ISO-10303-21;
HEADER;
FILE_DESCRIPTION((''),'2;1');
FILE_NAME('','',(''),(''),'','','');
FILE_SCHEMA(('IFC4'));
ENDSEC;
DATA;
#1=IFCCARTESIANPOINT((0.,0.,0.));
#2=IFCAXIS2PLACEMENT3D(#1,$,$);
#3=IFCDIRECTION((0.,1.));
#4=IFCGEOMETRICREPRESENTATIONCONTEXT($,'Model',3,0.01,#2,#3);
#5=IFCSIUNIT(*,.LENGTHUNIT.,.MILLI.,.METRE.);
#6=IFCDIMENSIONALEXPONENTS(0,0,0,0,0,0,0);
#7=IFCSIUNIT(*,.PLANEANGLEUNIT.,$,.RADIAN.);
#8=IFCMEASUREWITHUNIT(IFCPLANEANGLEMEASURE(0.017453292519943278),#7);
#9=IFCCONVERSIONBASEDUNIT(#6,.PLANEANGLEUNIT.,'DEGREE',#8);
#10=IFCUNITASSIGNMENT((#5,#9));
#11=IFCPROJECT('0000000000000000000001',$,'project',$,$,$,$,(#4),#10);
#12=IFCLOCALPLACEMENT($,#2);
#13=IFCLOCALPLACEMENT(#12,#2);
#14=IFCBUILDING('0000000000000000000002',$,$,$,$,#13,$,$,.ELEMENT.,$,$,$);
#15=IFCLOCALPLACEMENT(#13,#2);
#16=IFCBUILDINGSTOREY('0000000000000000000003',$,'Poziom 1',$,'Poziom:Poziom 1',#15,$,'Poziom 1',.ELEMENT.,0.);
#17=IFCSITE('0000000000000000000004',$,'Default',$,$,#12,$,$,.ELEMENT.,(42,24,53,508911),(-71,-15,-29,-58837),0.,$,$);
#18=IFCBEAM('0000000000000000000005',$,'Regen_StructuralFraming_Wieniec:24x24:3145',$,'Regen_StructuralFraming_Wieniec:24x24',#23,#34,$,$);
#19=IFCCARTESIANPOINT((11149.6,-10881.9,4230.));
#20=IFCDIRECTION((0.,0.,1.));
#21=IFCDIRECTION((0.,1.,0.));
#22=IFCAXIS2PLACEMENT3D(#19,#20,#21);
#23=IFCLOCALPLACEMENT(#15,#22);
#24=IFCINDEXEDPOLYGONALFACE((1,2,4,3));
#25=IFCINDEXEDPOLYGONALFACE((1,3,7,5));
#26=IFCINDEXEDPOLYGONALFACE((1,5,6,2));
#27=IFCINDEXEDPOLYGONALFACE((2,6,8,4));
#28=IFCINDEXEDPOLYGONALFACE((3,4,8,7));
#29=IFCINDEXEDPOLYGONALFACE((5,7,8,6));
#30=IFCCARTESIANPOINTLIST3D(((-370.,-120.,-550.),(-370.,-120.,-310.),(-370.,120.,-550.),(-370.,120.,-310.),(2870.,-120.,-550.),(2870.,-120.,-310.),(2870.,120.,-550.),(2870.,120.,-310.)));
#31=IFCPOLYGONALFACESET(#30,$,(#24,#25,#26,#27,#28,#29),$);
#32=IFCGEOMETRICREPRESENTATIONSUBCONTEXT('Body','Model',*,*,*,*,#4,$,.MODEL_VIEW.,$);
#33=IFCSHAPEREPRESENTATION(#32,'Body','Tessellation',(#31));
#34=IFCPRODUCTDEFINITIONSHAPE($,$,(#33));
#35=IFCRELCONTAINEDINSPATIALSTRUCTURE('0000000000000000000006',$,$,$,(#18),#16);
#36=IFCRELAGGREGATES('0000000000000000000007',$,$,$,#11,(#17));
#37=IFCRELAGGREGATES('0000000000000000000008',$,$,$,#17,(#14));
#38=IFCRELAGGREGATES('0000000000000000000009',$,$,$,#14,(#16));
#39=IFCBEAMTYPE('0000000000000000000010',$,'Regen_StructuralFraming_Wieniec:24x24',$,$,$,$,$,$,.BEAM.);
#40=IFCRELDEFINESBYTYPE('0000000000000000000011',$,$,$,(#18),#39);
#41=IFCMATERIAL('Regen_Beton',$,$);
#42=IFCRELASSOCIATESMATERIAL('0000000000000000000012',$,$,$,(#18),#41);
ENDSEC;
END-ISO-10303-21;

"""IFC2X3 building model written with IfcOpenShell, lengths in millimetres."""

from ifc_helpers import new_model, entity, si_unit, converted_unit, direction, frame, frame_2d, origin, place, context, subcontext, project, spatial, rectangle, extrude, material, type_object, element, save


model = new_model("IFC2X3")

# Units and contexts
model_context = context("Model", 3, precision=0.01, world=origin(), true_north=direction((0.0, 1.0)))
body_context = subcontext(model_context, "Body", "Model", "MODEL_VIEW")
ifc_project = project(units=[si_unit("LENGTHUNIT", "METRE", prefix="MILLI"), converted_unit("PLANEANGLEUNIT", "DEGREE", entity("IfcPlaneAngleMeasure", 0.017453292519943278), si_unit("PLANEANGLEUNIT", "RADIAN"), dimensions=[0, 0, 0, 0, 0, 0, 0])], contexts=[model_context])

# Site, building, storey
site_placement = place(None, origin())
site = spatial("IfcSite", under=ifc_project, at=site_placement, Name="Default", CompositionType="ELEMENT", RefLatitude=(42, 24, 53, 508911), RefLongitude=(-71, -15, -29, -58837), RefElevation=0.0)
building_placement = place(site_placement, origin())
building = spatial("IfcBuilding", under=site, at=building_placement, CompositionType="ELEMENT")
storey_placement = place(building_placement, origin())
storey = spatial("IfcBuildingStorey", under=building, at=storey_placement, Name="Poziom 1", ObjectType="Poziom:Poziom 1", LongName="Poziom 1", CompositionType="ELEMENT", Elevation=0.0)

# Beam
ifc_material_1 = material(Name="Regen_Beton")
beam_type_1 = type_object("IfcBeamType", Name="Regen_StructuralFraming_Wieniec:24x24", PredefinedType="BEAM")
beam_1_placement = place(storey_placement, frame((11149.6, -10881.9, 4230.0), z_axis=(0.0, 0.0, 1.0), x_axis=(0.0, 1.0, 0.0)))
element("IfcBeam", 1, at=beam_1_placement, inside=storey, type_object=beam_type_1, material=ifc_material_1, Name="Regen_StructuralFraming_Wieniec:24x24:3145", ObjectType="Regen_StructuralFraming_Wieniec:24x24", context=body_context, shape_type="SweptSolid", body=[
    extrude(rectangle(XDim=240.0, YDim=240.0, at=frame_2d((0.0, 0.0), x_axis=(1.0, 0.0))), frame((-370.0, 0.0, -430.0), z_axis=(1.0, 0.0, 0.0), x_axis=(0.0, 0.0, -1.0)), (0.0, 0.0, 1.0), 3240.0),
])

save(model, "model.ifc")
